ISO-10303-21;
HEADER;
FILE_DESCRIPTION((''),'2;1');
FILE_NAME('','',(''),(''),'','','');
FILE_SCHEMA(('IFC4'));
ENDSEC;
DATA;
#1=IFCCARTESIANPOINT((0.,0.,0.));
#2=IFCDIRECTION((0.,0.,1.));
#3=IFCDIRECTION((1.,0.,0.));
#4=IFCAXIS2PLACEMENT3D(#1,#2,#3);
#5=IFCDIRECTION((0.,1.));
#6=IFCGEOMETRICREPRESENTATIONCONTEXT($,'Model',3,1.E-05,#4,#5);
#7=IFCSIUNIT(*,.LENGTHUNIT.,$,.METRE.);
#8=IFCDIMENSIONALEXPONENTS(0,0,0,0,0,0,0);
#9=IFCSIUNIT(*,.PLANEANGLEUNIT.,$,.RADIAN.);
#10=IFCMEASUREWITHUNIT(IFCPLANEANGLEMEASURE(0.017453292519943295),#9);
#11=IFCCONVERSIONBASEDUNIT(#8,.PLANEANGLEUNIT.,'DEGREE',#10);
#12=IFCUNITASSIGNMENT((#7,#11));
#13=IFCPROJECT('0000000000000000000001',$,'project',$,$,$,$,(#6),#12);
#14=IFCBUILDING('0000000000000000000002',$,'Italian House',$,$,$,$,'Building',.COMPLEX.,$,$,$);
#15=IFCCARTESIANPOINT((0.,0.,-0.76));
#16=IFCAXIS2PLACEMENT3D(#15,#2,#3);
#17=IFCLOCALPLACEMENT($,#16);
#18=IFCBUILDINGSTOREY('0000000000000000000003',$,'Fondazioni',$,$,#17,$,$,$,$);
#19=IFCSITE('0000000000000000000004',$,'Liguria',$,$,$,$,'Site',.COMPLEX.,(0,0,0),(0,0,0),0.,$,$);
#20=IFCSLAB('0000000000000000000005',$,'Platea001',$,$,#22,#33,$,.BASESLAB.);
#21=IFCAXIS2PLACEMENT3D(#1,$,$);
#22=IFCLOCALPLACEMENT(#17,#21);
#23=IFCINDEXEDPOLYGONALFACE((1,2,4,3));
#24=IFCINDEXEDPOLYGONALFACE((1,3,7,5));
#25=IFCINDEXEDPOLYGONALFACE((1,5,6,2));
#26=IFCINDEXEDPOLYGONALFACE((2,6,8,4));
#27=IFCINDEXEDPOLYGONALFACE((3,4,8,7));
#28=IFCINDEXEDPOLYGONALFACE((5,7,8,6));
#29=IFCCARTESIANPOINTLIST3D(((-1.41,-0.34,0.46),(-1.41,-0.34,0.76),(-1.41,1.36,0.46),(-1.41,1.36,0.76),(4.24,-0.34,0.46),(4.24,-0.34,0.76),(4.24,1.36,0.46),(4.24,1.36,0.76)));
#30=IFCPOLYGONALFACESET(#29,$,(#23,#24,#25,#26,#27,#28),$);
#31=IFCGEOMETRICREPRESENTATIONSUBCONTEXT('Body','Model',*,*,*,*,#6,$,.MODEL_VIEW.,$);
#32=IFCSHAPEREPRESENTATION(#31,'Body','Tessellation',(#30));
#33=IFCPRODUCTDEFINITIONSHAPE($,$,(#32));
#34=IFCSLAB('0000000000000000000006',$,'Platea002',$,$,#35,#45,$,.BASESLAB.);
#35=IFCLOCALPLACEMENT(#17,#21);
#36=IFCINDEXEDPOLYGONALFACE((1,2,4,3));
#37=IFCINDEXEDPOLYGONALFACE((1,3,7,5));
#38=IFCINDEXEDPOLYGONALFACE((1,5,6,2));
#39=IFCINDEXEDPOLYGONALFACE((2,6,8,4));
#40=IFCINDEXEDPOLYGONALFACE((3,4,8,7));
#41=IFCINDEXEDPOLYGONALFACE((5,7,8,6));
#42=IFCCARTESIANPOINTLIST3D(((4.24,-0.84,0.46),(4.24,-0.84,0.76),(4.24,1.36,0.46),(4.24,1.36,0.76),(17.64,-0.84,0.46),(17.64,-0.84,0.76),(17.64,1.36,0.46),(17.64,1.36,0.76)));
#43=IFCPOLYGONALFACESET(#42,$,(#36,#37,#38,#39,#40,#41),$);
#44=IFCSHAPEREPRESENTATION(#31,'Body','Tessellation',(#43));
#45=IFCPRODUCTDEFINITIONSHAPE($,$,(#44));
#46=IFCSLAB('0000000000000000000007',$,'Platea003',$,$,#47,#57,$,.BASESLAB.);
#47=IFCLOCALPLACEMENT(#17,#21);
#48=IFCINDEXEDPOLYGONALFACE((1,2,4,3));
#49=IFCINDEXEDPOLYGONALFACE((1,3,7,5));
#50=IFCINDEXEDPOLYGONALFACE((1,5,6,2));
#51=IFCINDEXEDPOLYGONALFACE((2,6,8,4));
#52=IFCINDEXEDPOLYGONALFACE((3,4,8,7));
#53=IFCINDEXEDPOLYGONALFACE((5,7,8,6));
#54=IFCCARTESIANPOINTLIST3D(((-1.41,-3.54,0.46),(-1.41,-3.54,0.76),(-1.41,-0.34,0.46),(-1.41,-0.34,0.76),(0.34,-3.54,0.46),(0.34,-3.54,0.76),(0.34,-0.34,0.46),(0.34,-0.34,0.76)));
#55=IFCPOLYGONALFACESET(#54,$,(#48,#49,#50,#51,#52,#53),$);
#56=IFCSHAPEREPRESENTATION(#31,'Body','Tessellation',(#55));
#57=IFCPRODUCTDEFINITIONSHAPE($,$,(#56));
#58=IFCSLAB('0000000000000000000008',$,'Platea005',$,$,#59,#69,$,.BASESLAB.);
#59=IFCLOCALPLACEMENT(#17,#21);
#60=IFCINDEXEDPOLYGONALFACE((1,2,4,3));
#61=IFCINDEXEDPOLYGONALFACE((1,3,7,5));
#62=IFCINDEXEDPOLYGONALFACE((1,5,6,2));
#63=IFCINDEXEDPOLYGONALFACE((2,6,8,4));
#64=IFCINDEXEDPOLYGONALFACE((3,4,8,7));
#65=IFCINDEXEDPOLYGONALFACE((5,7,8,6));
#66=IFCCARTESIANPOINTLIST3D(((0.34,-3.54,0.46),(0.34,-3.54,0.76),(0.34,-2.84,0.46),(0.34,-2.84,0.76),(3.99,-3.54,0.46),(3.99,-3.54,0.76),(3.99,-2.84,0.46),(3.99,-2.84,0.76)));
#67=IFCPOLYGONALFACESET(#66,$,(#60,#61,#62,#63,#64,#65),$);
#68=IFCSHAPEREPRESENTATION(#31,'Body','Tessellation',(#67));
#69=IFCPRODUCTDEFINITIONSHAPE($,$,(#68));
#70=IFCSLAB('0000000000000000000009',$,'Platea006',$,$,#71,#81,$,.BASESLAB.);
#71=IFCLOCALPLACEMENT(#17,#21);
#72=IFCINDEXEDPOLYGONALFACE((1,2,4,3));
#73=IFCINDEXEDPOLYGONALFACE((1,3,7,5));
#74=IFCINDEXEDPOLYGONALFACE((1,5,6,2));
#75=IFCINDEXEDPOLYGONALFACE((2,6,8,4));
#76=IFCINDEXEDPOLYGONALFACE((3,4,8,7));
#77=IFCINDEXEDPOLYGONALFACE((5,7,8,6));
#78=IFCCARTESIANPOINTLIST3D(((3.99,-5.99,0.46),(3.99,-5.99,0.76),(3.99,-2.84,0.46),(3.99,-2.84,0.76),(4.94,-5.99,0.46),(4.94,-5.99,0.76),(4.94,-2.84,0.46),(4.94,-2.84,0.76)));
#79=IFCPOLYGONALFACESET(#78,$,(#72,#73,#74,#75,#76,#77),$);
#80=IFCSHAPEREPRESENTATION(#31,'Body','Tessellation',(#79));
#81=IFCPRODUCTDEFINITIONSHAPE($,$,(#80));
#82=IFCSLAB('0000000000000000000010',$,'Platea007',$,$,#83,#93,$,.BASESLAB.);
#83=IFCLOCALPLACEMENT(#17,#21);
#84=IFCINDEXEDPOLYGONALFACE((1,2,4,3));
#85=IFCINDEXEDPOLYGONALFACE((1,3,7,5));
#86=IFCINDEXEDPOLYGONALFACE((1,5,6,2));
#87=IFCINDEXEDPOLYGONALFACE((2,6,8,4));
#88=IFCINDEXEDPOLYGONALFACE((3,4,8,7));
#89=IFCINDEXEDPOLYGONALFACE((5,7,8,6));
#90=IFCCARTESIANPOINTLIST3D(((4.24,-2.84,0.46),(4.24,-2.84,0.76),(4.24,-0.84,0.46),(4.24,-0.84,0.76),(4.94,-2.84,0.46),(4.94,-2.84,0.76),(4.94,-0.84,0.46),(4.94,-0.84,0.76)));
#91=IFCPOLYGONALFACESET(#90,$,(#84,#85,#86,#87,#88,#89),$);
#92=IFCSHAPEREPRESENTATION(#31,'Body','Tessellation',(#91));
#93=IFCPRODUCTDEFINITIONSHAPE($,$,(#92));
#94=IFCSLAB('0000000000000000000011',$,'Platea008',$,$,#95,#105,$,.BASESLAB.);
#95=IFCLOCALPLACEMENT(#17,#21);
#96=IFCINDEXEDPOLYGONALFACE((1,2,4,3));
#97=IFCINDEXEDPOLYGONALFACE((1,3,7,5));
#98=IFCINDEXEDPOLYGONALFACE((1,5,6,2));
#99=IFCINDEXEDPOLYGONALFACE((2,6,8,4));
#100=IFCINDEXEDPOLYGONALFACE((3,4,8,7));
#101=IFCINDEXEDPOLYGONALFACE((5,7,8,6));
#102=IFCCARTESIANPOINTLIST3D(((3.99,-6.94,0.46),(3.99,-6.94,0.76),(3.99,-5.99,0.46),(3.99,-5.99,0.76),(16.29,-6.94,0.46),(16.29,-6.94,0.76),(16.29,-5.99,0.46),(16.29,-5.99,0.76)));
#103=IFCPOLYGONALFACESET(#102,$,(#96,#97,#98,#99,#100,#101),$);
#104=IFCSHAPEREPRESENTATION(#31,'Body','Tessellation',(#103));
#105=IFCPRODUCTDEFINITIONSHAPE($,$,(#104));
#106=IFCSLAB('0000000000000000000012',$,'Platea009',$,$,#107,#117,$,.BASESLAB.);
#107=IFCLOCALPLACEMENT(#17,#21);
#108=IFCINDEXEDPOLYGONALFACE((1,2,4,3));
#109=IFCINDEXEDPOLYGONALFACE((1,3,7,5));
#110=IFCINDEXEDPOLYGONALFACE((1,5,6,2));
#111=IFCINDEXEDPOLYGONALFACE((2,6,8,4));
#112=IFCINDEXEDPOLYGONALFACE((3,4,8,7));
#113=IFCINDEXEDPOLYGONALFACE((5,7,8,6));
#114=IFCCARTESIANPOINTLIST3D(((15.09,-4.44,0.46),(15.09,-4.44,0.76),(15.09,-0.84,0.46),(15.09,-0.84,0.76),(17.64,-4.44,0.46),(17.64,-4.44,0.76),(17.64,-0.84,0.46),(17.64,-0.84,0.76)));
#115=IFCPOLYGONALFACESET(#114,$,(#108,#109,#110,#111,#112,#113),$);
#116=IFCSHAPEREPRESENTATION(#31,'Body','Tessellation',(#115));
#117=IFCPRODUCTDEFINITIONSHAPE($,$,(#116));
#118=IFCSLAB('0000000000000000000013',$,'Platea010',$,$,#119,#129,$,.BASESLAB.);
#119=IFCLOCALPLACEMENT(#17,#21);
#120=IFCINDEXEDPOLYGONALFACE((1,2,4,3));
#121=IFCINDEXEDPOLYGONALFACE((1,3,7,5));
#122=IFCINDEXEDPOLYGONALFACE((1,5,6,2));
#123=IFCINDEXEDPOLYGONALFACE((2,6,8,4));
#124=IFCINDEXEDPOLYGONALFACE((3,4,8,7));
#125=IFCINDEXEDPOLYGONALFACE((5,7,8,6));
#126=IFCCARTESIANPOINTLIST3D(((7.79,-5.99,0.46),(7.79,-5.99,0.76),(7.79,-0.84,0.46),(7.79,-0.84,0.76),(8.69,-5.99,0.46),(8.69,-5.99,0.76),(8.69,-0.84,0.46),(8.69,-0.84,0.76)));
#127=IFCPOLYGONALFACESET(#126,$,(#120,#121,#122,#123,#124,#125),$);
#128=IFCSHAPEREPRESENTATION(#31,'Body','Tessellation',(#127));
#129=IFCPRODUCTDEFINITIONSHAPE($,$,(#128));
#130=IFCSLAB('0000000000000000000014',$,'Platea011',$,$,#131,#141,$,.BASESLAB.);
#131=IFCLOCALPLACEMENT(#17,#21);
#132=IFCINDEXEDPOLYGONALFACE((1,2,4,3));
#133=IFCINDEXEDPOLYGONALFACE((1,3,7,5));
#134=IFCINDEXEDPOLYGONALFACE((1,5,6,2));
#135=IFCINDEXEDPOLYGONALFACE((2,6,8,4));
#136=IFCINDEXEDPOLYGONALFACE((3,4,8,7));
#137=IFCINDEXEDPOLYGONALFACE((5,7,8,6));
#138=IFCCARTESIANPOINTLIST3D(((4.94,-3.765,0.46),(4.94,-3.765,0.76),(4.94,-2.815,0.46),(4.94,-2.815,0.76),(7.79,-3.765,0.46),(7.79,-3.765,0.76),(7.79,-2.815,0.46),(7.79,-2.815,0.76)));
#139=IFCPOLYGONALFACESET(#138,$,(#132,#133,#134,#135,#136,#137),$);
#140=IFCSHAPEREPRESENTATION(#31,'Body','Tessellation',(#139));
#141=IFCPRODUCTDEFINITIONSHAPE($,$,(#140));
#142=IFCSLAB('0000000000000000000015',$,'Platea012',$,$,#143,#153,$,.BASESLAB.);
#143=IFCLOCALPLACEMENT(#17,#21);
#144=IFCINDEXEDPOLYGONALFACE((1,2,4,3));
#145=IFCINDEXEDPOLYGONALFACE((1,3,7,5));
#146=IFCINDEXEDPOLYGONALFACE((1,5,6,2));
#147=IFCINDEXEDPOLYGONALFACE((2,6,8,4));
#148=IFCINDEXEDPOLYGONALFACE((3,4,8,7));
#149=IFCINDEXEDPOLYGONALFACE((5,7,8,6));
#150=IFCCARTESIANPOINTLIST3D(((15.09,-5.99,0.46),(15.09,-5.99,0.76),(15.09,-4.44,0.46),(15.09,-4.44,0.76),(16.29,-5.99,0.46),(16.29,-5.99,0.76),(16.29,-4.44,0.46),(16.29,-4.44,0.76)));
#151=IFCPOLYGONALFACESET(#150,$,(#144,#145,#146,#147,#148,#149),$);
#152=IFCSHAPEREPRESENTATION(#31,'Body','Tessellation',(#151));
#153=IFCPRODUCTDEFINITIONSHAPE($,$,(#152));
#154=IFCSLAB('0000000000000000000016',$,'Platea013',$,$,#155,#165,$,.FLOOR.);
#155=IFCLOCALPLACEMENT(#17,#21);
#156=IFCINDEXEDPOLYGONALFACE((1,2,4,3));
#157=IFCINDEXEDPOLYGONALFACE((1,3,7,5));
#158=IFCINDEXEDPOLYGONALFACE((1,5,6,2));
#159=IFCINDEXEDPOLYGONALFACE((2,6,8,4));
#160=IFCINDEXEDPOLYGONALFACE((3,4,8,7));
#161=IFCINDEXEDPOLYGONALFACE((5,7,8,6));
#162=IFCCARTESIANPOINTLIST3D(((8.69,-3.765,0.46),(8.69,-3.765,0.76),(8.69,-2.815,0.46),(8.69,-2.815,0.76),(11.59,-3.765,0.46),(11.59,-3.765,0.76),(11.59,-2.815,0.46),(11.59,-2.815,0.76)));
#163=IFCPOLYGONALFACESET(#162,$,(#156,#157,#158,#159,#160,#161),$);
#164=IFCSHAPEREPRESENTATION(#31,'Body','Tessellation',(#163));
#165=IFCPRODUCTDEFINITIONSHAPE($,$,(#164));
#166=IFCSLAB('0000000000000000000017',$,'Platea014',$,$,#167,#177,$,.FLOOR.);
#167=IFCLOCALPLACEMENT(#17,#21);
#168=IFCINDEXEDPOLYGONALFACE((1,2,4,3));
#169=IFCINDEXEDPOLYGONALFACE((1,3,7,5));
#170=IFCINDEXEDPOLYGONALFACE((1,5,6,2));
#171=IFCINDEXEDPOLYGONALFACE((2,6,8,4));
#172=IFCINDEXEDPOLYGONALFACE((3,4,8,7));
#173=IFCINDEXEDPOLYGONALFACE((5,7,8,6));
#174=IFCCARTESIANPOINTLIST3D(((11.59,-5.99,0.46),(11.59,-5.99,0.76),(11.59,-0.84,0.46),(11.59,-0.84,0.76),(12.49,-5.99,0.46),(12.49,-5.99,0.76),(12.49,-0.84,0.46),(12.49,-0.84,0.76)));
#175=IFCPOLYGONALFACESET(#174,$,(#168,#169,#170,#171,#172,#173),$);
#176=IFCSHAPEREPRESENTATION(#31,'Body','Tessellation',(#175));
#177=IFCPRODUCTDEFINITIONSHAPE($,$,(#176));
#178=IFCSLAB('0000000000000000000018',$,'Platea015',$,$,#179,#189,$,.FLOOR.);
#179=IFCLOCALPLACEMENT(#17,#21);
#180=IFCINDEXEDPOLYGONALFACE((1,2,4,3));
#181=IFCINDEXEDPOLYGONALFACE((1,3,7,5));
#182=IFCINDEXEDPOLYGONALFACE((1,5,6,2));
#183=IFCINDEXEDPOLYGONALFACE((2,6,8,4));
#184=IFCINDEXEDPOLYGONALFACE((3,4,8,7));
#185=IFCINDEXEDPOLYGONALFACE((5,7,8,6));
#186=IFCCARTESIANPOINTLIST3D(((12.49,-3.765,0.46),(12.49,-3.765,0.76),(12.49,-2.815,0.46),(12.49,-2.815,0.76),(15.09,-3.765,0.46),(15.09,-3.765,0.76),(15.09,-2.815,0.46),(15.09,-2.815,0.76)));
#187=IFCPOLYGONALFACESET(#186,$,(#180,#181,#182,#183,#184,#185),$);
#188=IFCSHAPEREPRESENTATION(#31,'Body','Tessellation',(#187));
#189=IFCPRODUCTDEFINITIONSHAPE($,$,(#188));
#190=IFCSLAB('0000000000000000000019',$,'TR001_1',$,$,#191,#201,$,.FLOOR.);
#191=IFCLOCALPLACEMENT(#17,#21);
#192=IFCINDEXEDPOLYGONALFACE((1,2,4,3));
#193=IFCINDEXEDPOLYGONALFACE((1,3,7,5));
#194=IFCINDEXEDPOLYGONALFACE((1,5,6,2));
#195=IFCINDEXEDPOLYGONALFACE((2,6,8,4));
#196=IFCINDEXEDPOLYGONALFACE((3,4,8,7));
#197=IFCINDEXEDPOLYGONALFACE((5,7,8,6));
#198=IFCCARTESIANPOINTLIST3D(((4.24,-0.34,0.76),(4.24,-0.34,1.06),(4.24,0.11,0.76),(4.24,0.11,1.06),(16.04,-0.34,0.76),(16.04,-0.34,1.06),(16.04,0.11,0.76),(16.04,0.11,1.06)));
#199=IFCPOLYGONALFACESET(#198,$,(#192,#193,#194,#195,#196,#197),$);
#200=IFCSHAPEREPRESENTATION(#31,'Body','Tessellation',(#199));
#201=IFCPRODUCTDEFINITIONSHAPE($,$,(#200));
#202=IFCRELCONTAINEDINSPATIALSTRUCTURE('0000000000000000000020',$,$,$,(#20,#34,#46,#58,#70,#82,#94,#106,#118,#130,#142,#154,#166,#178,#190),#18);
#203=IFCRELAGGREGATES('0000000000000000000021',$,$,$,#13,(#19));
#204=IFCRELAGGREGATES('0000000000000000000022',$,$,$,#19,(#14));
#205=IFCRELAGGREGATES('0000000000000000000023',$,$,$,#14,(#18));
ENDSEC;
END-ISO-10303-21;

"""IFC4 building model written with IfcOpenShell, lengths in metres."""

from ifc_helpers import new_model, entity, si_unit, converted_unit, direction, frame, frame_2d, origin_with_axes, origin_2d_with_axis, place, context, subcontext, project, spatial, rectangle, extrude, element, save


model = new_model("IFC4")

# Units and contexts
model_context = context("Model", 3, precision=1e-05, world=origin_with_axes(), true_north=direction((0.0, 1.0)))
body_context = subcontext(model_context, "Body", "Model", "MODEL_VIEW")
ifc_project = project(units=[si_unit("LENGTHUNIT", "METRE"), converted_unit("PLANEANGLEUNIT", "DEGREE", entity("IfcPlaneAngleMeasure", 0.017453292519943295), si_unit("PLANEANGLEUNIT", "RADIAN"), dimensions=[0, 0, 0, 0, 0, 0, 0])], contexts=[model_context])

# Site, building, storey
site = spatial("IfcSite", under=ifc_project, Name="Liguria", LongName="Site", CompositionType="COMPLEX", RefLatitude=(0, 0, 0), RefLongitude=(0, 0, 0), RefElevation=0.0)
building = spatial("IfcBuilding", under=site, Name="Italian House", LongName="Building", CompositionType="COMPLEX")
storey_placement = place(None, frame((0.0, 0.0, -0.76), z_axis=(0.0, 0.0, 1.0), x_axis=(1.0, 0.0, 0.0)))
storey = spatial("IfcBuildingStorey", under=building, at=storey_placement, Name="Fondazioni")

# Slabs
slab_1_placement = place(storey_placement, frame((0.0, 0.0, 0.76), z_axis=(0.0, 0.0, 1.0), x_axis=(1.0, 0.0, 0.0)))
element("IfcSlab", 1, at=slab_1_placement, inside=storey, Name="Platea001", PredefinedType="BASESLAB", context=body_context, shape_type="SweptSolid", body=[
    extrude(rectangle(XDim=5.65, YDim=1.7, at=origin_2d_with_axis()), frame((1.415, 0.51, 0.0), z_axis=(0.0, 0.0, 1.0), x_axis=(1.0, 0.0, 0.0)), (0.0, 0.0, -1.0), 0.3),
])
slab_2_placement = place(storey_placement, frame((0.0, 0.0, 0.76), z_axis=(0.0, 0.0, 1.0), x_axis=(1.0, 0.0, 0.0)))
element("IfcSlab", 2, at=slab_2_placement, inside=storey, Name="Platea002", PredefinedType="BASESLAB", context=body_context, shape_type="SweptSolid", body=[
    extrude(rectangle(XDim=13.4, YDim=2.2, at=origin_2d_with_axis()), frame((10.94, 0.26, 0.0), z_axis=(0.0, 0.0, 1.0), x_axis=(1.0, 0.0, 0.0)), (0.0, 0.0, -1.0), 0.3),
])
slab_3_placement = place(storey_placement, frame((0.0, 0.0, 0.76), z_axis=(0.0, 0.0, 1.0), x_axis=(1.0, 0.0, 0.0)))
element("IfcSlab", 3, at=slab_3_placement, inside=storey, Name="Platea003", PredefinedType="BASESLAB", context=body_context, shape_type="SweptSolid", body=[
    extrude(rectangle(XDim=1.75, YDim=3.2, at=origin_2d_with_axis()), frame((-0.535, -1.94, 0.0), z_axis=(0.0, 0.0, 1.0), x_axis=(1.0, 0.0, 0.0)), (0.0, 0.0, -1.0), 0.3),
])
slab_4_placement = place(storey_placement, frame((0.0, 0.0, 0.76), z_axis=(0.0, 0.0, 1.0), x_axis=(1.0, 0.0, 0.0)))
element("IfcSlab", 4, at=slab_4_placement, inside=storey, Name="Platea005", PredefinedType="BASESLAB", context=body_context, shape_type="SweptSolid", body=[
    extrude(rectangle(XDim=3.65, YDim=0.7, at=frame_2d((0.0, 0.0), x_axis=(1.0, 0.0))), frame((2.165, -3.19, 0.0), z_axis=(0.0, 0.0, 1.0), x_axis=(1.0, 0.0, 0.0)), (0.0, 0.0, -1.0), 0.3),
])
slab_5_placement = place(storey_placement, frame((0.0, 0.0, 0.76), z_axis=(0.0, 0.0, 1.0), x_axis=(1.0, 0.0, 0.0)))
element("IfcSlab", 5, at=slab_5_placement, inside=storey, Name="Platea006", PredefinedType="BASESLAB", context=body_context, shape_type="SweptSolid", body=[
    extrude(rectangle(XDim=0.95, YDim=3.15, at=origin_2d_with_axis()), frame((4.465, -4.415, 0.0), z_axis=(0.0, 0.0, 1.0), x_axis=(1.0, 0.0, 0.0)), (0.0, 0.0, -1.0), 0.3),
])
slab_6_placement = place(storey_placement, frame((0.0, 0.0, 0.76), z_axis=(0.0, 0.0, 1.0), x_axis=(1.0, 0.0, 0.0)))
element("IfcSlab", 6, at=slab_6_placement, inside=storey, Name="Platea007", PredefinedType="BASESLAB", context=body_context, shape_type="SweptSolid", body=[
    extrude(rectangle(XDim=0.7, YDim=2.0, at=frame_2d((0.0, 0.0), x_axis=(1.0, 0.0))), frame((4.59, -1.84, 0.0), z_axis=(0.0, 0.0, 1.0), x_axis=(1.0, 0.0, 0.0)), (0.0, 0.0, -1.0), 0.3),
])
slab_7_placement = place(storey_placement, frame((0.0, 0.0, 0.76), z_axis=(0.0, 0.0, 1.0), x_axis=(1.0, 0.0, 0.0)))
element("IfcSlab", 7, at=slab_7_placement, inside=storey, Name="Platea008", PredefinedType="BASESLAB", context=body_context, shape_type="SweptSolid", body=[
    extrude(rectangle(XDim=12.3, YDim=0.95, at=origin_2d_with_axis()), frame((10.14, -6.465, 0.0), z_axis=(0.0, 0.0, 1.0), x_axis=(1.0, 0.0, 0.0)), (0.0, 0.0, -1.0), 0.3),
])
slab_8_placement = place(storey_placement, frame((0.0, 0.0, 0.76), z_axis=(0.0, 0.0, 1.0), x_axis=(1.0, 0.0, 0.0)))
element("IfcSlab", 8, at=slab_8_placement, inside=storey, Name="Platea009", PredefinedType="BASESLAB", context=body_context, shape_type="SweptSolid", body=[
    extrude(rectangle(XDim=2.55, YDim=3.6, at=origin_2d_with_axis()), frame((16.365, -2.64, 0.0), z_axis=(0.0, 0.0, 1.0), x_axis=(1.0, 0.0, 0.0)), (0.0, 0.0, -1.0), 0.3),
])
slab_9_placement = place(storey_placement, frame((0.0, 0.0, 0.76), z_axis=(0.0, 0.0, 1.0), x_axis=(1.0, 0.0, 0.0)))
element("IfcSlab", 9, at=slab_9_placement, inside=storey, Name="Platea010", PredefinedType="BASESLAB", context=body_context, shape_type="SweptSolid", body=[
    extrude(rectangle(XDim=0.9, YDim=5.15, at=origin_2d_with_axis()), frame((8.24, -3.415, 0.0), z_axis=(0.0, 0.0, 1.0), x_axis=(1.0, 0.0, 0.0)), (0.0, 0.0, -1.0), 0.3),
])
slab_10_placement = place(storey_placement, frame((0.0, 0.0, 0.76), z_axis=(0.0, 0.0, 1.0), x_axis=(1.0, 0.0, 0.0)))
element("IfcSlab", 10, at=slab_10_placement, inside=storey, Name="Platea011", PredefinedType="BASESLAB", context=body_context, shape_type="SweptSolid", body=[
    extrude(rectangle(XDim=2.85, YDim=0.95, at=frame_2d((0.0, 0.0), x_axis=(1.0, 0.0))), frame((6.365, -3.29, 0.0), z_axis=(0.0, 0.0, 1.0), x_axis=(1.0, 0.0, 0.0)), (0.0, 0.0, -1.0), 0.3),
])
slab_11_placement = place(storey_placement, frame((0.0, 0.0, 0.76), z_axis=(0.0, 0.0, 1.0), x_axis=(1.0, 0.0, 0.0)))
element("IfcSlab", 11, at=slab_11_placement, inside=storey, Name="Platea012", PredefinedType="BASESLAB", context=body_context, shape_type="SweptSolid", body=[
    extrude(rectangle(XDim=1.2, YDim=1.55, at=origin_2d_with_axis()), frame((15.69, -5.215, 0.0), z_axis=(0.0, 0.0, 1.0), x_axis=(1.0, 0.0, 0.0)), (0.0, 0.0, -1.0), 0.3),
])
slab_12_placement = place(storey_placement, frame((0.0, 0.0, 0.76), z_axis=(0.0, 0.0, 1.0), x_axis=(1.0, 0.0, 0.0)))
element("IfcSlab", 12, at=slab_12_placement, inside=storey, Name="Platea013", PredefinedType="FLOOR", context=body_context, shape_type="SweptSolid", body=[
    extrude(rectangle(XDim=2.9, YDim=0.95, at=frame_2d((0.0, 0.0), x_axis=(1.0, 0.0))), frame((10.14, -3.29, 0.0), z_axis=(0.0, 0.0, 1.0), x_axis=(1.0, 0.0, 0.0)), (0.0, 0.0, -1.0), 0.3),
])
slab_13_placement = place(storey_placement, frame((0.0, 0.0, 0.76), z_axis=(0.0, 0.0, 1.0), x_axis=(1.0, 0.0, 0.0)))
element("IfcSlab", 13, at=slab_13_placement, inside=storey, Name="Platea014", PredefinedType="FLOOR", context=body_context, shape_type="SweptSolid", body=[
    extrude(rectangle(XDim=0.9, YDim=5.15, at=origin_2d_with_axis()), frame((12.04, -3.415, 0.0), z_axis=(0.0, 0.0, 1.0), x_axis=(1.0, 0.0, 0.0)), (0.0, 0.0, -1.0), 0.3),
])
slab_14_placement = place(storey_placement, frame((0.0, 0.0, 0.76), z_axis=(0.0, 0.0, 1.0), x_axis=(1.0, 0.0, 0.0)))
element("IfcSlab", 14, at=slab_14_placement, inside=storey, Name="Platea015", PredefinedType="FLOOR", context=body_context, shape_type="SweptSolid", body=[
    extrude(rectangle(XDim=2.6, YDim=0.95, at=frame_2d((0.0, 0.0), x_axis=(1.0, 0.0))), frame((13.79, -3.29, 0.0), z_axis=(0.0, 0.0, 1.0), x_axis=(1.0, 0.0, 0.0)), (0.0, 0.0, -1.0), 0.3),
])
slab_15_placement = place(storey_placement, frame((0.0, 0.0, 0.76), z_axis=(0.0, 0.0, 1.0), x_axis=(1.0, 0.0, 0.0)))
element("IfcSlab", 15, at=slab_15_placement, inside=storey, Name="TR001_1", PredefinedType="FLOOR", context=body_context, shape_type="SweptSolid", body=[
    extrude(rectangle(XDim=11.8, YDim=0.45, at=origin_2d_with_axis()), frame((10.14, -0.115, 0.3), z_axis=(0.0, 0.0, 1.0), x_axis=(1.0, 0.0, 0.0)), (0.0, 0.0, -1.0), 0.3),
])

save(model, "model.ifc")
